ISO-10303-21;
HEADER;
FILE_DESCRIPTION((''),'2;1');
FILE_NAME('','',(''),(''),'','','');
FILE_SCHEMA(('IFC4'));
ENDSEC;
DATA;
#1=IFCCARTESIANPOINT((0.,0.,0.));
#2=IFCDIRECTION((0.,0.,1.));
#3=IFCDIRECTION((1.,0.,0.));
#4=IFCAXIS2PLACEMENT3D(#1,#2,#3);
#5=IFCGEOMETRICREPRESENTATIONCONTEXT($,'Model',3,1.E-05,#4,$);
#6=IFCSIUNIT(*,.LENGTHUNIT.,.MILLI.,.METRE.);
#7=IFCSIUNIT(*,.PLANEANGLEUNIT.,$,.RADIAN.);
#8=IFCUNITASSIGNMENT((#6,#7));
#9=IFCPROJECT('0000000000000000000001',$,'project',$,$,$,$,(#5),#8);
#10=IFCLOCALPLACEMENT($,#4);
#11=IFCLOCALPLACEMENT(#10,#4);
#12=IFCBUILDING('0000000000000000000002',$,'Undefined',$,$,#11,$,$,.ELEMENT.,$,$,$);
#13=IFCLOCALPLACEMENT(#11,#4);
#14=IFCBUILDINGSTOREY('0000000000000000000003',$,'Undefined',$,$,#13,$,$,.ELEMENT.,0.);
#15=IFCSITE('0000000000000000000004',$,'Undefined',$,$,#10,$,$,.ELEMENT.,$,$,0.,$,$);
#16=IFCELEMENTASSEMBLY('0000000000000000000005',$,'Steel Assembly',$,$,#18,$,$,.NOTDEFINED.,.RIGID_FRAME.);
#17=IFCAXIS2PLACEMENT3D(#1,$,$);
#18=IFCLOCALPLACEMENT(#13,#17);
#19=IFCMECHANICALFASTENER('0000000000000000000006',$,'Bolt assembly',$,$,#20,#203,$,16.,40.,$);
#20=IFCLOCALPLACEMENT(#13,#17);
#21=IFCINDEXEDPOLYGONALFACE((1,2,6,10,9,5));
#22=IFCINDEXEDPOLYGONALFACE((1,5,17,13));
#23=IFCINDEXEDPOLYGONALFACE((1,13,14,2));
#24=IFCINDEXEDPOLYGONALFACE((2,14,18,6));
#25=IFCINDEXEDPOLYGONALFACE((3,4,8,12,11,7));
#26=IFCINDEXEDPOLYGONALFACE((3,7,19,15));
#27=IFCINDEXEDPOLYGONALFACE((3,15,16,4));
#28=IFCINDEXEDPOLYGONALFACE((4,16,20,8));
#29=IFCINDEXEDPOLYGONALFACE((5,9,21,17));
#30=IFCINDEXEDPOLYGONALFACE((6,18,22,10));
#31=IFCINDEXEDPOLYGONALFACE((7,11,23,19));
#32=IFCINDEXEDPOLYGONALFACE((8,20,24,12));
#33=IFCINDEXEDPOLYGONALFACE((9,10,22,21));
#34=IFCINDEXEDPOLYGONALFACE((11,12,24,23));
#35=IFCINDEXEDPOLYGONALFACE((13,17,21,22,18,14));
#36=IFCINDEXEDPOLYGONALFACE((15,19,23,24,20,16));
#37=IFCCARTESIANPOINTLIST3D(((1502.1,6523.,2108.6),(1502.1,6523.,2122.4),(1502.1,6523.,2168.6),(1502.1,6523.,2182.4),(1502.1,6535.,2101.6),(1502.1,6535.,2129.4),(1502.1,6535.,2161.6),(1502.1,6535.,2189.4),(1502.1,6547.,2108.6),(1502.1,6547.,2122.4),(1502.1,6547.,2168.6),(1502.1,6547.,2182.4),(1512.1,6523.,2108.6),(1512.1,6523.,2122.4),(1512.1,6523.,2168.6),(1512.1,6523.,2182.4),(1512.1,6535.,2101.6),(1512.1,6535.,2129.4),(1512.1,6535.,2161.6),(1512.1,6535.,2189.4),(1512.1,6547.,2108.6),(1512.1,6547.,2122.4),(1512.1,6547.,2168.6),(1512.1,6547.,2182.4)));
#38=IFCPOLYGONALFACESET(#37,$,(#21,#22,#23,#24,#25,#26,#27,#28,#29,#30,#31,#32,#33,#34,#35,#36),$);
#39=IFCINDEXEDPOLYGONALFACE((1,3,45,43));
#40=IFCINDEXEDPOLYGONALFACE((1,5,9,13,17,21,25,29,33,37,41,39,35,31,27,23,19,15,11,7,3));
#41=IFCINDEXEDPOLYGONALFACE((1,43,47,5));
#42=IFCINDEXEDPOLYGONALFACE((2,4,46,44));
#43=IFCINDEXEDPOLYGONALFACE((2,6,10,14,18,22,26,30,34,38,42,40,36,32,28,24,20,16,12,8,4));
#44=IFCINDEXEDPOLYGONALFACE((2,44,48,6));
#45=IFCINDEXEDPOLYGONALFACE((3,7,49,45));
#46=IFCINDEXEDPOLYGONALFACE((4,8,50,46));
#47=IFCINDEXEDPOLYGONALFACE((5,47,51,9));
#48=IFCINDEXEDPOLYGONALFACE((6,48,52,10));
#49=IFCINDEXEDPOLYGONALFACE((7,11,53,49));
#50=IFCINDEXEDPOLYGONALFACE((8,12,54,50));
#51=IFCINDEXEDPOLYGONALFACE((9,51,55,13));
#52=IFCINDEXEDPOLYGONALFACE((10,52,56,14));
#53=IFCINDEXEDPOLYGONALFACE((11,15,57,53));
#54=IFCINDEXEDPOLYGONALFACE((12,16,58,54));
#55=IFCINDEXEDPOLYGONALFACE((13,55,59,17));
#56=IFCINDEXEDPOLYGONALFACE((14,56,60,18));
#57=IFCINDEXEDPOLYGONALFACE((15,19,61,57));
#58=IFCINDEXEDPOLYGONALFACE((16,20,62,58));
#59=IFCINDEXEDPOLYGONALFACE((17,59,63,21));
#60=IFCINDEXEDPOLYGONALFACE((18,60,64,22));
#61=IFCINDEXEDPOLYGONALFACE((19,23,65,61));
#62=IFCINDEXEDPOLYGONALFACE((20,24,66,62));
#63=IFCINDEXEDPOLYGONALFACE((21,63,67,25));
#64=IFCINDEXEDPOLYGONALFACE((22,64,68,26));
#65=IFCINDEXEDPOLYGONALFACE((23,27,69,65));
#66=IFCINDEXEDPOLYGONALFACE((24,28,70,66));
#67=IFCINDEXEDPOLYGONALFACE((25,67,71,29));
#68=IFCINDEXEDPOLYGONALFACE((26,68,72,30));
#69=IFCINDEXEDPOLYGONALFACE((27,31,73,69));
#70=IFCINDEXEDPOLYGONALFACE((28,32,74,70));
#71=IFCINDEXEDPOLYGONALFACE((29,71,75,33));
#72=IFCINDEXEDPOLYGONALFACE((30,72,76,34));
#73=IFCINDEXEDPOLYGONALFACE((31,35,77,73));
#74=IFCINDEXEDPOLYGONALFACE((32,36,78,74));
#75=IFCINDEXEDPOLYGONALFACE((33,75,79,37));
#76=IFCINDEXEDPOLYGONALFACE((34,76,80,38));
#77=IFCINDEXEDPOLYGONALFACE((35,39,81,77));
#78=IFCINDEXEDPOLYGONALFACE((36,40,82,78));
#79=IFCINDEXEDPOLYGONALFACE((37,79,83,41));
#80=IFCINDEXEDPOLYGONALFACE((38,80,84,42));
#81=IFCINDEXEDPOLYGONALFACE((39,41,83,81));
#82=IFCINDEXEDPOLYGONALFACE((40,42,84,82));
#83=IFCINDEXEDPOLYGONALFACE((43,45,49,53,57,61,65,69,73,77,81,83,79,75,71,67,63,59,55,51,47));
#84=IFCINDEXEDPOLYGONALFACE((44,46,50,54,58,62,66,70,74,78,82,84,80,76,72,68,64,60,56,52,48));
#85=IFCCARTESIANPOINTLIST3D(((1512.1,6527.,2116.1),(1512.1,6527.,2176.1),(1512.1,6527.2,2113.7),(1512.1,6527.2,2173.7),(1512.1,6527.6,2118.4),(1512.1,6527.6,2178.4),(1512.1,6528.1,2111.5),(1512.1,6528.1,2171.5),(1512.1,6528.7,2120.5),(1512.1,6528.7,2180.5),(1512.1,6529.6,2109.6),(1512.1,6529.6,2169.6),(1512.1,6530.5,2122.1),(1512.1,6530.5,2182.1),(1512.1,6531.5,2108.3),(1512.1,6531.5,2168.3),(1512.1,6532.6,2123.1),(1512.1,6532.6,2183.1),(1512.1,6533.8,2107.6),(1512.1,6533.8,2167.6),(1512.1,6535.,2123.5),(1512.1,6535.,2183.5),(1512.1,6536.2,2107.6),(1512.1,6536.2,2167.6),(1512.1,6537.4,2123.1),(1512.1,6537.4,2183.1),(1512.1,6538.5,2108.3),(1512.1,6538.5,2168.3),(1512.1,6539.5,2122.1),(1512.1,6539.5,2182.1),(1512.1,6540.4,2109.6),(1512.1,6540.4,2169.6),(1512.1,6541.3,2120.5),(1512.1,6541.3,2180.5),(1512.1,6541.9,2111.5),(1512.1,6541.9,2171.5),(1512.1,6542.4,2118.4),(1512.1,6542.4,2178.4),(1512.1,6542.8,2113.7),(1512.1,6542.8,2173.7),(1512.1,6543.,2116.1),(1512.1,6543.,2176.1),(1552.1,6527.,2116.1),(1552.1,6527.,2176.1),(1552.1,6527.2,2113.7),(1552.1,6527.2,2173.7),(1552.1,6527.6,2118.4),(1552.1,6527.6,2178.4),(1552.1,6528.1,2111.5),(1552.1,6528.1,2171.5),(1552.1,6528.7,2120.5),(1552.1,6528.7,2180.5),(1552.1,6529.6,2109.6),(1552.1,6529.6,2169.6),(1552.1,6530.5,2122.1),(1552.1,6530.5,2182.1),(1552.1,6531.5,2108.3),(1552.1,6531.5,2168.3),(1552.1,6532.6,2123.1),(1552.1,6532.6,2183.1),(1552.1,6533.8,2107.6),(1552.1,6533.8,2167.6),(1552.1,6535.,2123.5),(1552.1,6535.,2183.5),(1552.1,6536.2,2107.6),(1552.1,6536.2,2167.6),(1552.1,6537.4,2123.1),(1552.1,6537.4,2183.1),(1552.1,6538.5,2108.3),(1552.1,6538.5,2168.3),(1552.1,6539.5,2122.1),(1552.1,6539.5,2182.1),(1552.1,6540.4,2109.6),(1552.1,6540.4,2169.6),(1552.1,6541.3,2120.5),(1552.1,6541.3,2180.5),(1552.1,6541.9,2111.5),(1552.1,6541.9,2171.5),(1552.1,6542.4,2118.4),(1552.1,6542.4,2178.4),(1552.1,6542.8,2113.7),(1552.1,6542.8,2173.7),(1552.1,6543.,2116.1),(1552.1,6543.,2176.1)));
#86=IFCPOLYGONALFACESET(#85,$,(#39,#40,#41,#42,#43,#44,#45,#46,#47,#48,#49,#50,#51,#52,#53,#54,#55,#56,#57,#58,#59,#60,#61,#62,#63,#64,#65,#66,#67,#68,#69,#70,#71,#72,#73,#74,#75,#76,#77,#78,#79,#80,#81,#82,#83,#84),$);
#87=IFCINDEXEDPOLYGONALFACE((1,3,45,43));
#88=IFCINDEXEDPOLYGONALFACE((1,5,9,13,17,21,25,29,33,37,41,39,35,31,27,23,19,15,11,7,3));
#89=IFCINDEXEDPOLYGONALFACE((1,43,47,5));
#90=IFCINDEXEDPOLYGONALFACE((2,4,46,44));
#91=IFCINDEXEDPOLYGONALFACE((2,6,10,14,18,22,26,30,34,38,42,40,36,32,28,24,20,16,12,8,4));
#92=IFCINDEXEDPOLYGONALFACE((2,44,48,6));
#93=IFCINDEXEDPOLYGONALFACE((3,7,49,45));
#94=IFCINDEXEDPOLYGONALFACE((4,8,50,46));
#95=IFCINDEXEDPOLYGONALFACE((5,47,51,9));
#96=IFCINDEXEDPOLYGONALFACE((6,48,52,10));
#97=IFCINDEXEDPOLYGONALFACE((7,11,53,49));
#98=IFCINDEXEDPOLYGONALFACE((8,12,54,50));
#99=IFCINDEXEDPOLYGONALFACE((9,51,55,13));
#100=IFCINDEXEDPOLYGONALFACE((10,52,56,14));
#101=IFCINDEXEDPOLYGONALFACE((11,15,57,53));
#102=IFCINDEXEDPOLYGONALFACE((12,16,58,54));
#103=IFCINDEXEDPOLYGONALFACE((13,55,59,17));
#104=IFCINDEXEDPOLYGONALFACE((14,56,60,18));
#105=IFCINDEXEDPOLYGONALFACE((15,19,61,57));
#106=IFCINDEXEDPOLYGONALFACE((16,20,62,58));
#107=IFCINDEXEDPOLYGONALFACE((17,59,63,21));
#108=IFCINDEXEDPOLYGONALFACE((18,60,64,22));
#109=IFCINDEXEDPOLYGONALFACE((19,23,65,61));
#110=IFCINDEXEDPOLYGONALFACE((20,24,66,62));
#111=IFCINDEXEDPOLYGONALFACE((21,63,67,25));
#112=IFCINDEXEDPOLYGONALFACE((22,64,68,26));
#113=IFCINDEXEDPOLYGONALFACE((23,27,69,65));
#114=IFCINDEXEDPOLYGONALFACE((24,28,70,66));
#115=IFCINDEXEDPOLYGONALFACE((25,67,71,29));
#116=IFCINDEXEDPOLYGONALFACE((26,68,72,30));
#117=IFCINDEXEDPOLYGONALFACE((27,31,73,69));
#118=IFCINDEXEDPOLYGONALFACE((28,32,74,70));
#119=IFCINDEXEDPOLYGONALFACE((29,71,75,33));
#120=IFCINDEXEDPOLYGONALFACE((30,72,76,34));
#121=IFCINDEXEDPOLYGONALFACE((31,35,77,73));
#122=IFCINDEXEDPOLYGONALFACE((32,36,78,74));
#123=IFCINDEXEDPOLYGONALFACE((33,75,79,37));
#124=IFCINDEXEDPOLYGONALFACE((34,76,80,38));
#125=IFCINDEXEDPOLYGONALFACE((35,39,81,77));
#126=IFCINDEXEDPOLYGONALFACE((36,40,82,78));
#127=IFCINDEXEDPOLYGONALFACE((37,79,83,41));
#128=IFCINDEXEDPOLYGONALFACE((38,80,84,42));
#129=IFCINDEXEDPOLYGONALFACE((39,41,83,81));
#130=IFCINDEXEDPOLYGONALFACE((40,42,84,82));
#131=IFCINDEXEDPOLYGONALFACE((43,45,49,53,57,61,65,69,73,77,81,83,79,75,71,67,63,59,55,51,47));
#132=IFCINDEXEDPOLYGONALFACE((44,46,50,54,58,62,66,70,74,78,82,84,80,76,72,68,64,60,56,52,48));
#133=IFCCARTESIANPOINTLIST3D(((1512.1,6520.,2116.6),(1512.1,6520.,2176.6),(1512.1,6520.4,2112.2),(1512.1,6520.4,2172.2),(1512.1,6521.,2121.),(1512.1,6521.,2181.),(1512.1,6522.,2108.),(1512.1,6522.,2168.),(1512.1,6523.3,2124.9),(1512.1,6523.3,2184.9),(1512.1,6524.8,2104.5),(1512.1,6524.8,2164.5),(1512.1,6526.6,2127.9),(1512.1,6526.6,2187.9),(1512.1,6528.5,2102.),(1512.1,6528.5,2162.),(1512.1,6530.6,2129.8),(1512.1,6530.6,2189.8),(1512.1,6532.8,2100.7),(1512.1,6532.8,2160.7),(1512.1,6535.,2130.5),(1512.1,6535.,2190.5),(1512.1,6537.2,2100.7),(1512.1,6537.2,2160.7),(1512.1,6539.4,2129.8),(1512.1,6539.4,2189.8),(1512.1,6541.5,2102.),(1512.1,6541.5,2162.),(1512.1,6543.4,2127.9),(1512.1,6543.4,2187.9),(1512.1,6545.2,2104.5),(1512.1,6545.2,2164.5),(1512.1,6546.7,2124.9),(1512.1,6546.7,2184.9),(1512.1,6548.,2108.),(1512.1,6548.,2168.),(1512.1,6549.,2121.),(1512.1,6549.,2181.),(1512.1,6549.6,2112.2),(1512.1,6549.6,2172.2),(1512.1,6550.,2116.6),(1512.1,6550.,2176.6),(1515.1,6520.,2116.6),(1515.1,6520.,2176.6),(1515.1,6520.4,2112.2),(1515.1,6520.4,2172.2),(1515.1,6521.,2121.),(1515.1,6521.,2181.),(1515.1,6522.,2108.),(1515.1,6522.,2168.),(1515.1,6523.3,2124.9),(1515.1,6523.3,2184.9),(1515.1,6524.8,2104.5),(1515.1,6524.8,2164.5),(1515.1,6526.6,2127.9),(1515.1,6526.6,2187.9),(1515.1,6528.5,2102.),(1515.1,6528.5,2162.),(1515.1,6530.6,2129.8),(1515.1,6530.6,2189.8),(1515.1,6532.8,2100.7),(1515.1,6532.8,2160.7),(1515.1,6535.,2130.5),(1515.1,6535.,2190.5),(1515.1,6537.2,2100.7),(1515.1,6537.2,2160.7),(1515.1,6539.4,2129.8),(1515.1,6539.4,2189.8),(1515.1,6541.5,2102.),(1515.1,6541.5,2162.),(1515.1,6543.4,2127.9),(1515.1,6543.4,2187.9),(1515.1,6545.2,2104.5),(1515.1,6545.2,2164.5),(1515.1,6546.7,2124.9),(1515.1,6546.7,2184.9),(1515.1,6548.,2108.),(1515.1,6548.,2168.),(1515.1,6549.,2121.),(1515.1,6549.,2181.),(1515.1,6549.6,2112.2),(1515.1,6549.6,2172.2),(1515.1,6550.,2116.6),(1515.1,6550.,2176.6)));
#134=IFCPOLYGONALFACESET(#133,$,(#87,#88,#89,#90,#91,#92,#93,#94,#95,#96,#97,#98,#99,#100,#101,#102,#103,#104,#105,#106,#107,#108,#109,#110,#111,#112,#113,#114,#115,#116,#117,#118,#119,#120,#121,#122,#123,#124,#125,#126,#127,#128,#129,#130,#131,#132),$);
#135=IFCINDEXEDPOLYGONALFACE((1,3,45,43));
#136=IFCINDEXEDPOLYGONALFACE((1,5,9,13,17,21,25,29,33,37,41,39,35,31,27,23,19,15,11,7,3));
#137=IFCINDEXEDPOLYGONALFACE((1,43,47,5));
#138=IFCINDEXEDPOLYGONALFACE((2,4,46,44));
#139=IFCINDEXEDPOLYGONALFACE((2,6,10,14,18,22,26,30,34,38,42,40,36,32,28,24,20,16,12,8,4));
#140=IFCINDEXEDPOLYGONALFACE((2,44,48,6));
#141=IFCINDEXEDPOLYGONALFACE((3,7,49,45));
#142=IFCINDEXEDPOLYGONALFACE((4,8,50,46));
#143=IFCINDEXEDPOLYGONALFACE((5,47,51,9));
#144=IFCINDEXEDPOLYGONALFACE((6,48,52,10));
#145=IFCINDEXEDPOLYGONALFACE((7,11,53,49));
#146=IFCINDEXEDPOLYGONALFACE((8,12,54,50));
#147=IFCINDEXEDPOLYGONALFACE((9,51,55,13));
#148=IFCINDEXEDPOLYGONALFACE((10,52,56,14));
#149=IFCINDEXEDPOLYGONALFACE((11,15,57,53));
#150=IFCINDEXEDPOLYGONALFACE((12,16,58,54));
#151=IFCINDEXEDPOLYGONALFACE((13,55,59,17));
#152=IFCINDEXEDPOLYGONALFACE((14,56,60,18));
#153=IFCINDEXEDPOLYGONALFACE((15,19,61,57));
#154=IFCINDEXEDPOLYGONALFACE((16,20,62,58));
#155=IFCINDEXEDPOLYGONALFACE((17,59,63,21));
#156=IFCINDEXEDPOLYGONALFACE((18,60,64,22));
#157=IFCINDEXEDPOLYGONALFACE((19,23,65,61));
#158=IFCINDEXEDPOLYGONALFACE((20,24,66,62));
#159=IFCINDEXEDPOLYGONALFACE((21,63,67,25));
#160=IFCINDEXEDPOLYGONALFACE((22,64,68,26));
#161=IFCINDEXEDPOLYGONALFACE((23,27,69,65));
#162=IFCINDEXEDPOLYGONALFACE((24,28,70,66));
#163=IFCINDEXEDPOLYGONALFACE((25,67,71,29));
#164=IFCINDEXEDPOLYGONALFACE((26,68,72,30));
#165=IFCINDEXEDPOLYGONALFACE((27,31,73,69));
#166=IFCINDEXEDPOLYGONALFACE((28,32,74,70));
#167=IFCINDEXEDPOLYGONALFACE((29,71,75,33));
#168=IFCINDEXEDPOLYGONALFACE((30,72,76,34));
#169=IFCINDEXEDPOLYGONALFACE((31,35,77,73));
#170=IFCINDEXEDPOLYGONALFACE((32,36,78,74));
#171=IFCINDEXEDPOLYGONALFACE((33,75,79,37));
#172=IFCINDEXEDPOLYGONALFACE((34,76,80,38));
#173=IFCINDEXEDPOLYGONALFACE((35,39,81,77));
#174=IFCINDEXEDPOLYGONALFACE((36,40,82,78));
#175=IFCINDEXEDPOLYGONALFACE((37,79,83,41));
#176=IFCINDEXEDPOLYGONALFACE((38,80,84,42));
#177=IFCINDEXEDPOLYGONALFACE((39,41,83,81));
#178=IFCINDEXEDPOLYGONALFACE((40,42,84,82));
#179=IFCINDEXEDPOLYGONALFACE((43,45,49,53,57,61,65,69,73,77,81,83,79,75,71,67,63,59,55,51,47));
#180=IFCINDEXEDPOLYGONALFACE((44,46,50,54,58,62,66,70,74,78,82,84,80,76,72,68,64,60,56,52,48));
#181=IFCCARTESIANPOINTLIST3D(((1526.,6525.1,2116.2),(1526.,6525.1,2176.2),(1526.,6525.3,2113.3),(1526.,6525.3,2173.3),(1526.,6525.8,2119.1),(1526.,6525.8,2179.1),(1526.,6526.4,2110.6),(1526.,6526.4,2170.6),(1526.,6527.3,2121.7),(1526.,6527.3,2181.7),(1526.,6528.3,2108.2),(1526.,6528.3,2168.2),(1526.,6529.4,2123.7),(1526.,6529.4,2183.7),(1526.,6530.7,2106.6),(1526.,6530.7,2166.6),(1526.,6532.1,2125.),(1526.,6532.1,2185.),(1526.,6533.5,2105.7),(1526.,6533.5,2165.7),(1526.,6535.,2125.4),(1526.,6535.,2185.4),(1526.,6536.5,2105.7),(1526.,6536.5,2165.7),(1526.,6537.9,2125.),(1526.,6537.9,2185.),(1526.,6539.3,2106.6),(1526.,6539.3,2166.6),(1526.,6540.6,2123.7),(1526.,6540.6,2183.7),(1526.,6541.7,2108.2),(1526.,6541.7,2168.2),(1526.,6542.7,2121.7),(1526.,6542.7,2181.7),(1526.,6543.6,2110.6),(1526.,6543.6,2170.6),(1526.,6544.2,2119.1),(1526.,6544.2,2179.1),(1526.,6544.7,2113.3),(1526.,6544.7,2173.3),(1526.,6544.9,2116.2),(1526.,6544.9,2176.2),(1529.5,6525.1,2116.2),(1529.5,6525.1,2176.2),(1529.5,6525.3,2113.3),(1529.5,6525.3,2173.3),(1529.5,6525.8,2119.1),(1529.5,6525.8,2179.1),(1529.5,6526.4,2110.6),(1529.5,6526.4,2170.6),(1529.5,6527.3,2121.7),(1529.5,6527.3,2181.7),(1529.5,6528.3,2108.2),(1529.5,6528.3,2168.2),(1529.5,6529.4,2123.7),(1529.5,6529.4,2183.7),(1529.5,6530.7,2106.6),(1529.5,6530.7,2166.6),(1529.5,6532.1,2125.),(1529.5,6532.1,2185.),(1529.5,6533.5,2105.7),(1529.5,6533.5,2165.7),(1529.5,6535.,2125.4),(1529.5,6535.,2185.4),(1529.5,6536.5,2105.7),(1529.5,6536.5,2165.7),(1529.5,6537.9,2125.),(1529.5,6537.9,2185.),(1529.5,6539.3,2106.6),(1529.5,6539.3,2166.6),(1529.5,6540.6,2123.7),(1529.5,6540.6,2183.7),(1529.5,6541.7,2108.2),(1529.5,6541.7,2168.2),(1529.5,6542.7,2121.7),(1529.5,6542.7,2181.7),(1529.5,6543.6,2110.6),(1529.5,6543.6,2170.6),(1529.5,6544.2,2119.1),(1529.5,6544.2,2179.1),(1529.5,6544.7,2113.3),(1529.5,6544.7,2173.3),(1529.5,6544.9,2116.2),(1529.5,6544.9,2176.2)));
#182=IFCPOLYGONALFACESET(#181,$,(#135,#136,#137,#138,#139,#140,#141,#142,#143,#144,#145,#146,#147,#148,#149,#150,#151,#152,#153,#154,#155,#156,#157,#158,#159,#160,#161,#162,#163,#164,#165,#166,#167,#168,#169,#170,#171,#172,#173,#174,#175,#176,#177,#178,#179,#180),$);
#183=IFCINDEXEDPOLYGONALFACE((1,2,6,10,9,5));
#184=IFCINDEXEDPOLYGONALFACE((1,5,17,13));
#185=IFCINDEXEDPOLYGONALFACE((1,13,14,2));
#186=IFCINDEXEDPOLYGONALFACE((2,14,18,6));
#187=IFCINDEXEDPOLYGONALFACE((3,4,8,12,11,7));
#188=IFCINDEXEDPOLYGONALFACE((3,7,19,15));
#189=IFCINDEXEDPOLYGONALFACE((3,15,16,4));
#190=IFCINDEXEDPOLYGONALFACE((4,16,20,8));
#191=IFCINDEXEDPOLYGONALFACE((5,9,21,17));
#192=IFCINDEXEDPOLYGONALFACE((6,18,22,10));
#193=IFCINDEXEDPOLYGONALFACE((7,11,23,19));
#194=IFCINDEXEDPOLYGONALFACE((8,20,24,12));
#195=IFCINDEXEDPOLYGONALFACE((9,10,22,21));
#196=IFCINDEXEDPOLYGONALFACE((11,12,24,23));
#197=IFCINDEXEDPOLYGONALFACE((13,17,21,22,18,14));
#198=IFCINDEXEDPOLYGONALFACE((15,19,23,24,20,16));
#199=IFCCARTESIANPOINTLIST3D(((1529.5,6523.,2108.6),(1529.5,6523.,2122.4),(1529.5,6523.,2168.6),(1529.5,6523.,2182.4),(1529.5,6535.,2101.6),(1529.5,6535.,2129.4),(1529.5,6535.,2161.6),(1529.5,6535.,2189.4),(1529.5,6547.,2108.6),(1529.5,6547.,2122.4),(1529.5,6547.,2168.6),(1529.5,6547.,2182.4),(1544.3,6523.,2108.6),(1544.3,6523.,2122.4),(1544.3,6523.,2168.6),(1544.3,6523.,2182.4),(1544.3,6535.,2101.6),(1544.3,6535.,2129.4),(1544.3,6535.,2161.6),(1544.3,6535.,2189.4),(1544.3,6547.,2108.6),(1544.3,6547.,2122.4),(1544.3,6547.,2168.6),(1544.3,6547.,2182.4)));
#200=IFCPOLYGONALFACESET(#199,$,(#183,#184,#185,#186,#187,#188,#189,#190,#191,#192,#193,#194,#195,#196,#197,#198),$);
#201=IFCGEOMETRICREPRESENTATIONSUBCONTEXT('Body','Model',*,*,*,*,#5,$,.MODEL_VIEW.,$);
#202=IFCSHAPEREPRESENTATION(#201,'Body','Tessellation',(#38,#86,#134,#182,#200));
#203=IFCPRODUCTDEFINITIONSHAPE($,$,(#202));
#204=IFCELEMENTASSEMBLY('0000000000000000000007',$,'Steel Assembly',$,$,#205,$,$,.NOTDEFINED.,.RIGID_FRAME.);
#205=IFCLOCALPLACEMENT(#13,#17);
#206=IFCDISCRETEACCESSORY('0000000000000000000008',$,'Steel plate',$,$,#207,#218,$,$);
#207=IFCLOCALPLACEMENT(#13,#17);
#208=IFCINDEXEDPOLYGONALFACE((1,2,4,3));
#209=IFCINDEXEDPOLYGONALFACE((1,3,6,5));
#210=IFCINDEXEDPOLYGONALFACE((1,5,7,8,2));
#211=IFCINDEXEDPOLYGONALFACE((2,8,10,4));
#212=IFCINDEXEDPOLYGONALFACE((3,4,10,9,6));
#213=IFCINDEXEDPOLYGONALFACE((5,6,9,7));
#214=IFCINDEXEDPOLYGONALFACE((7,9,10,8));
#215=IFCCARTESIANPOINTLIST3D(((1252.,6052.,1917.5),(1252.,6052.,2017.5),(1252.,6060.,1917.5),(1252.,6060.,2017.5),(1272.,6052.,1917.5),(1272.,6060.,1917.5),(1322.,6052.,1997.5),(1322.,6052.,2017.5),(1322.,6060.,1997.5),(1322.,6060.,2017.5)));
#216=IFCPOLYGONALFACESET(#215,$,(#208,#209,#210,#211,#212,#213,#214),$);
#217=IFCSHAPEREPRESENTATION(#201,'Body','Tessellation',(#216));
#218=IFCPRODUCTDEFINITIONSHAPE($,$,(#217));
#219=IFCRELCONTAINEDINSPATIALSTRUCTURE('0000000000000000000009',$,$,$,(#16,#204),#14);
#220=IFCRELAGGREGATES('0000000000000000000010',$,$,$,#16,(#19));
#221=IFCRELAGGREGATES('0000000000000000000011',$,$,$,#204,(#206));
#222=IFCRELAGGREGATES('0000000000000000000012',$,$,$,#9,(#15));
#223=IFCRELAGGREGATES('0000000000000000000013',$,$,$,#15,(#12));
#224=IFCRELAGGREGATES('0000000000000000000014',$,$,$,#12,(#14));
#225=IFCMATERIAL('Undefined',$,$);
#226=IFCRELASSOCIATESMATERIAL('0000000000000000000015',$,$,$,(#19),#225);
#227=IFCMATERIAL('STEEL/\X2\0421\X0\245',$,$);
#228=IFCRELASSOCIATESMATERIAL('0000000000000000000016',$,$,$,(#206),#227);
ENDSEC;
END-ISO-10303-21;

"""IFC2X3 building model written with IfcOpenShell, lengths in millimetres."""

from ifc_helpers import new_model, si_unit, frame, origin_with_axes, origin_2d_with_axis, place, context, subcontext, project, spatial, polyline, circle, outline, extrude, source, transform, mapped, material, element, aggregate, save


model = new_model("IFC2X3")

# Units and contexts
model_context = context("Model", 3, precision=1e-05, world=origin_with_axes())
body_context = subcontext(model_context, "Body", "Model", "MODEL_VIEW")
ifc_project = project(units=[si_unit("LENGTHUNIT", "METRE", prefix="MILLI"), si_unit("PLANEANGLEUNIT", "RADIAN")], contexts=[model_context])

# Site, building, storey
site_placement = place(None, origin_with_axes())
site = spatial("IfcSite", under=ifc_project, at=site_placement, Name="Undefined", CompositionType="ELEMENT", RefElevation=0.0)
building_placement = place(site_placement, origin_with_axes())
building = spatial("IfcBuilding", under=site, at=building_placement, Name="Undefined", CompositionType="ELEMENT")
storey_placement = place(building_placement, origin_with_axes())
storey = spatial("IfcBuildingStorey", under=building, at=storey_placement, Name="Undefined", CompositionType="ELEMENT", Elevation=0.0)

# Shared definitions
ifc_material_1 = material(Name="STEEL/С245")

# Element assembly, mechanical fastener
assembly_1_placement = place(storey_placement, origin_with_axes())
assembly_1 = element("IfcElementAssembly", 1, at=assembly_1_placement, inside=storey, Name="Steel Assembly", AssemblyPlace="NOTDEFINED", PredefinedType="RIGID_FRAME")
ifc_material_2 = material(Name="Undefined")
shared_shape_1 = source(origin_with_axes(), body_context, "Body", "SweptSolid", [
    extrude(outline(polyline([(13.9, 0.0), (6.9, 12.0), (-6.9, 12.0), (-13.9, 0.0), (-6.9, -12.0), (6.9, -12.0), (13.9, 0.0)])), frame((0.0, -17.9, 0.0), z_axis=(0.0, 1.0, 0.0), x_axis=(1.0, 0.0, 0.0)), (0.0, 0.0, 1.0), 10.0),
    extrude(circle(Radius=8.0, at=origin_2d_with_axis()), frame((0.0, -7.9, 0.0), z_axis=(0.0, 1.0, 0.0), x_axis=(1.0, 0.0, 0.0)), (0.0, 0.0, 1.0), 40.0),
    extrude(circle(Radius=15.0, at=origin_2d_with_axis()), frame((0.0, -7.9, 0.0), z_axis=(0.0, 1.0, 0.0), x_axis=(1.0, 0.0, 0.0)), (0.0, 0.0, 1.0), 3.0),
    extrude(circle(Radius=9.9, at=origin_2d_with_axis()), frame((0.0, 6.0, 0.0), z_axis=(0.0, 1.0, 0.0), x_axis=(1.0, 0.0, 0.0)), (0.0, 0.0, 1.0), 3.5),
    extrude(outline(polyline([(13.9, 0.0), (6.9, 12.0), (-6.9, 12.0), (-13.9, 0.0), (-6.9, -12.0), (6.9, -12.0), (13.9, 0.0)])), frame((0.0, 9.5, 0.0), z_axis=(0.0, 1.0, 0.0), x_axis=(1.0, 0.0, 0.0)), (0.0, 0.0, 1.0), 14.8),
])
mechanical_fastener_placement = place(assembly_1_placement, frame((1520.0, 6535.0, 2115.5), z_axis=(0.0, 1.0, 0.0), x_axis=(0.0, 0.0, 1.0)))
mechanical_fastener = element("IfcMechanicalFastener", 2, at=mechanical_fastener_placement, material=ifc_material_2, Name="Bolt assembly", NominalDiameter=16.0, NominalLength=40.0, context=body_context, shape_type="MappedRepresentation", body=[
    mapped(shared_shape_1, transform((0.0, 0.0, 0.0))),
    mapped(shared_shape_1, transform((60.0, 0.0, 0.0))),
])
aggregate(assembly_1, [mechanical_fastener])

# Element assembly, discrete accessory
assembly_2_placement = place(storey_placement, origin_with_axes())
assembly_2 = element("IfcElementAssembly", 3, at=assembly_2_placement, inside=storey, Name="Steel Assembly", AssemblyPlace="NOTDEFINED", PredefinedType="RIGID_FRAME")
discrete_accessory_1_placement = place(assembly_2_placement, frame((1252.0, 6056.0, 2017.5), z_axis=(0.0, -1.0, 0.0), x_axis=(0.0, 0.0, -1.0)))
discrete_accessory_1 = element("IfcDiscreteAccessory", 4, at=discrete_accessory_1_placement, material=ifc_material_1, Name="Steel plate", context=body_context, shape_type="SweptSolid", body=[
    extrude(outline(polyline([(0.0, 0.0), (100.0, 0.0), (100.0, 20.0), (20.0, 70.0), (0.0, 70.0), (0.0, 0.0)])), frame((0.0, 0.0, -4.0), z_axis=(0.0, 0.0, 1.0), x_axis=(1.0, 0.0, 0.0)), (0.0, 0.0, 1.0), 8.0),
])

aggregate(assembly_2, [discrete_accessory_1])

save(model, "model.ifc")
